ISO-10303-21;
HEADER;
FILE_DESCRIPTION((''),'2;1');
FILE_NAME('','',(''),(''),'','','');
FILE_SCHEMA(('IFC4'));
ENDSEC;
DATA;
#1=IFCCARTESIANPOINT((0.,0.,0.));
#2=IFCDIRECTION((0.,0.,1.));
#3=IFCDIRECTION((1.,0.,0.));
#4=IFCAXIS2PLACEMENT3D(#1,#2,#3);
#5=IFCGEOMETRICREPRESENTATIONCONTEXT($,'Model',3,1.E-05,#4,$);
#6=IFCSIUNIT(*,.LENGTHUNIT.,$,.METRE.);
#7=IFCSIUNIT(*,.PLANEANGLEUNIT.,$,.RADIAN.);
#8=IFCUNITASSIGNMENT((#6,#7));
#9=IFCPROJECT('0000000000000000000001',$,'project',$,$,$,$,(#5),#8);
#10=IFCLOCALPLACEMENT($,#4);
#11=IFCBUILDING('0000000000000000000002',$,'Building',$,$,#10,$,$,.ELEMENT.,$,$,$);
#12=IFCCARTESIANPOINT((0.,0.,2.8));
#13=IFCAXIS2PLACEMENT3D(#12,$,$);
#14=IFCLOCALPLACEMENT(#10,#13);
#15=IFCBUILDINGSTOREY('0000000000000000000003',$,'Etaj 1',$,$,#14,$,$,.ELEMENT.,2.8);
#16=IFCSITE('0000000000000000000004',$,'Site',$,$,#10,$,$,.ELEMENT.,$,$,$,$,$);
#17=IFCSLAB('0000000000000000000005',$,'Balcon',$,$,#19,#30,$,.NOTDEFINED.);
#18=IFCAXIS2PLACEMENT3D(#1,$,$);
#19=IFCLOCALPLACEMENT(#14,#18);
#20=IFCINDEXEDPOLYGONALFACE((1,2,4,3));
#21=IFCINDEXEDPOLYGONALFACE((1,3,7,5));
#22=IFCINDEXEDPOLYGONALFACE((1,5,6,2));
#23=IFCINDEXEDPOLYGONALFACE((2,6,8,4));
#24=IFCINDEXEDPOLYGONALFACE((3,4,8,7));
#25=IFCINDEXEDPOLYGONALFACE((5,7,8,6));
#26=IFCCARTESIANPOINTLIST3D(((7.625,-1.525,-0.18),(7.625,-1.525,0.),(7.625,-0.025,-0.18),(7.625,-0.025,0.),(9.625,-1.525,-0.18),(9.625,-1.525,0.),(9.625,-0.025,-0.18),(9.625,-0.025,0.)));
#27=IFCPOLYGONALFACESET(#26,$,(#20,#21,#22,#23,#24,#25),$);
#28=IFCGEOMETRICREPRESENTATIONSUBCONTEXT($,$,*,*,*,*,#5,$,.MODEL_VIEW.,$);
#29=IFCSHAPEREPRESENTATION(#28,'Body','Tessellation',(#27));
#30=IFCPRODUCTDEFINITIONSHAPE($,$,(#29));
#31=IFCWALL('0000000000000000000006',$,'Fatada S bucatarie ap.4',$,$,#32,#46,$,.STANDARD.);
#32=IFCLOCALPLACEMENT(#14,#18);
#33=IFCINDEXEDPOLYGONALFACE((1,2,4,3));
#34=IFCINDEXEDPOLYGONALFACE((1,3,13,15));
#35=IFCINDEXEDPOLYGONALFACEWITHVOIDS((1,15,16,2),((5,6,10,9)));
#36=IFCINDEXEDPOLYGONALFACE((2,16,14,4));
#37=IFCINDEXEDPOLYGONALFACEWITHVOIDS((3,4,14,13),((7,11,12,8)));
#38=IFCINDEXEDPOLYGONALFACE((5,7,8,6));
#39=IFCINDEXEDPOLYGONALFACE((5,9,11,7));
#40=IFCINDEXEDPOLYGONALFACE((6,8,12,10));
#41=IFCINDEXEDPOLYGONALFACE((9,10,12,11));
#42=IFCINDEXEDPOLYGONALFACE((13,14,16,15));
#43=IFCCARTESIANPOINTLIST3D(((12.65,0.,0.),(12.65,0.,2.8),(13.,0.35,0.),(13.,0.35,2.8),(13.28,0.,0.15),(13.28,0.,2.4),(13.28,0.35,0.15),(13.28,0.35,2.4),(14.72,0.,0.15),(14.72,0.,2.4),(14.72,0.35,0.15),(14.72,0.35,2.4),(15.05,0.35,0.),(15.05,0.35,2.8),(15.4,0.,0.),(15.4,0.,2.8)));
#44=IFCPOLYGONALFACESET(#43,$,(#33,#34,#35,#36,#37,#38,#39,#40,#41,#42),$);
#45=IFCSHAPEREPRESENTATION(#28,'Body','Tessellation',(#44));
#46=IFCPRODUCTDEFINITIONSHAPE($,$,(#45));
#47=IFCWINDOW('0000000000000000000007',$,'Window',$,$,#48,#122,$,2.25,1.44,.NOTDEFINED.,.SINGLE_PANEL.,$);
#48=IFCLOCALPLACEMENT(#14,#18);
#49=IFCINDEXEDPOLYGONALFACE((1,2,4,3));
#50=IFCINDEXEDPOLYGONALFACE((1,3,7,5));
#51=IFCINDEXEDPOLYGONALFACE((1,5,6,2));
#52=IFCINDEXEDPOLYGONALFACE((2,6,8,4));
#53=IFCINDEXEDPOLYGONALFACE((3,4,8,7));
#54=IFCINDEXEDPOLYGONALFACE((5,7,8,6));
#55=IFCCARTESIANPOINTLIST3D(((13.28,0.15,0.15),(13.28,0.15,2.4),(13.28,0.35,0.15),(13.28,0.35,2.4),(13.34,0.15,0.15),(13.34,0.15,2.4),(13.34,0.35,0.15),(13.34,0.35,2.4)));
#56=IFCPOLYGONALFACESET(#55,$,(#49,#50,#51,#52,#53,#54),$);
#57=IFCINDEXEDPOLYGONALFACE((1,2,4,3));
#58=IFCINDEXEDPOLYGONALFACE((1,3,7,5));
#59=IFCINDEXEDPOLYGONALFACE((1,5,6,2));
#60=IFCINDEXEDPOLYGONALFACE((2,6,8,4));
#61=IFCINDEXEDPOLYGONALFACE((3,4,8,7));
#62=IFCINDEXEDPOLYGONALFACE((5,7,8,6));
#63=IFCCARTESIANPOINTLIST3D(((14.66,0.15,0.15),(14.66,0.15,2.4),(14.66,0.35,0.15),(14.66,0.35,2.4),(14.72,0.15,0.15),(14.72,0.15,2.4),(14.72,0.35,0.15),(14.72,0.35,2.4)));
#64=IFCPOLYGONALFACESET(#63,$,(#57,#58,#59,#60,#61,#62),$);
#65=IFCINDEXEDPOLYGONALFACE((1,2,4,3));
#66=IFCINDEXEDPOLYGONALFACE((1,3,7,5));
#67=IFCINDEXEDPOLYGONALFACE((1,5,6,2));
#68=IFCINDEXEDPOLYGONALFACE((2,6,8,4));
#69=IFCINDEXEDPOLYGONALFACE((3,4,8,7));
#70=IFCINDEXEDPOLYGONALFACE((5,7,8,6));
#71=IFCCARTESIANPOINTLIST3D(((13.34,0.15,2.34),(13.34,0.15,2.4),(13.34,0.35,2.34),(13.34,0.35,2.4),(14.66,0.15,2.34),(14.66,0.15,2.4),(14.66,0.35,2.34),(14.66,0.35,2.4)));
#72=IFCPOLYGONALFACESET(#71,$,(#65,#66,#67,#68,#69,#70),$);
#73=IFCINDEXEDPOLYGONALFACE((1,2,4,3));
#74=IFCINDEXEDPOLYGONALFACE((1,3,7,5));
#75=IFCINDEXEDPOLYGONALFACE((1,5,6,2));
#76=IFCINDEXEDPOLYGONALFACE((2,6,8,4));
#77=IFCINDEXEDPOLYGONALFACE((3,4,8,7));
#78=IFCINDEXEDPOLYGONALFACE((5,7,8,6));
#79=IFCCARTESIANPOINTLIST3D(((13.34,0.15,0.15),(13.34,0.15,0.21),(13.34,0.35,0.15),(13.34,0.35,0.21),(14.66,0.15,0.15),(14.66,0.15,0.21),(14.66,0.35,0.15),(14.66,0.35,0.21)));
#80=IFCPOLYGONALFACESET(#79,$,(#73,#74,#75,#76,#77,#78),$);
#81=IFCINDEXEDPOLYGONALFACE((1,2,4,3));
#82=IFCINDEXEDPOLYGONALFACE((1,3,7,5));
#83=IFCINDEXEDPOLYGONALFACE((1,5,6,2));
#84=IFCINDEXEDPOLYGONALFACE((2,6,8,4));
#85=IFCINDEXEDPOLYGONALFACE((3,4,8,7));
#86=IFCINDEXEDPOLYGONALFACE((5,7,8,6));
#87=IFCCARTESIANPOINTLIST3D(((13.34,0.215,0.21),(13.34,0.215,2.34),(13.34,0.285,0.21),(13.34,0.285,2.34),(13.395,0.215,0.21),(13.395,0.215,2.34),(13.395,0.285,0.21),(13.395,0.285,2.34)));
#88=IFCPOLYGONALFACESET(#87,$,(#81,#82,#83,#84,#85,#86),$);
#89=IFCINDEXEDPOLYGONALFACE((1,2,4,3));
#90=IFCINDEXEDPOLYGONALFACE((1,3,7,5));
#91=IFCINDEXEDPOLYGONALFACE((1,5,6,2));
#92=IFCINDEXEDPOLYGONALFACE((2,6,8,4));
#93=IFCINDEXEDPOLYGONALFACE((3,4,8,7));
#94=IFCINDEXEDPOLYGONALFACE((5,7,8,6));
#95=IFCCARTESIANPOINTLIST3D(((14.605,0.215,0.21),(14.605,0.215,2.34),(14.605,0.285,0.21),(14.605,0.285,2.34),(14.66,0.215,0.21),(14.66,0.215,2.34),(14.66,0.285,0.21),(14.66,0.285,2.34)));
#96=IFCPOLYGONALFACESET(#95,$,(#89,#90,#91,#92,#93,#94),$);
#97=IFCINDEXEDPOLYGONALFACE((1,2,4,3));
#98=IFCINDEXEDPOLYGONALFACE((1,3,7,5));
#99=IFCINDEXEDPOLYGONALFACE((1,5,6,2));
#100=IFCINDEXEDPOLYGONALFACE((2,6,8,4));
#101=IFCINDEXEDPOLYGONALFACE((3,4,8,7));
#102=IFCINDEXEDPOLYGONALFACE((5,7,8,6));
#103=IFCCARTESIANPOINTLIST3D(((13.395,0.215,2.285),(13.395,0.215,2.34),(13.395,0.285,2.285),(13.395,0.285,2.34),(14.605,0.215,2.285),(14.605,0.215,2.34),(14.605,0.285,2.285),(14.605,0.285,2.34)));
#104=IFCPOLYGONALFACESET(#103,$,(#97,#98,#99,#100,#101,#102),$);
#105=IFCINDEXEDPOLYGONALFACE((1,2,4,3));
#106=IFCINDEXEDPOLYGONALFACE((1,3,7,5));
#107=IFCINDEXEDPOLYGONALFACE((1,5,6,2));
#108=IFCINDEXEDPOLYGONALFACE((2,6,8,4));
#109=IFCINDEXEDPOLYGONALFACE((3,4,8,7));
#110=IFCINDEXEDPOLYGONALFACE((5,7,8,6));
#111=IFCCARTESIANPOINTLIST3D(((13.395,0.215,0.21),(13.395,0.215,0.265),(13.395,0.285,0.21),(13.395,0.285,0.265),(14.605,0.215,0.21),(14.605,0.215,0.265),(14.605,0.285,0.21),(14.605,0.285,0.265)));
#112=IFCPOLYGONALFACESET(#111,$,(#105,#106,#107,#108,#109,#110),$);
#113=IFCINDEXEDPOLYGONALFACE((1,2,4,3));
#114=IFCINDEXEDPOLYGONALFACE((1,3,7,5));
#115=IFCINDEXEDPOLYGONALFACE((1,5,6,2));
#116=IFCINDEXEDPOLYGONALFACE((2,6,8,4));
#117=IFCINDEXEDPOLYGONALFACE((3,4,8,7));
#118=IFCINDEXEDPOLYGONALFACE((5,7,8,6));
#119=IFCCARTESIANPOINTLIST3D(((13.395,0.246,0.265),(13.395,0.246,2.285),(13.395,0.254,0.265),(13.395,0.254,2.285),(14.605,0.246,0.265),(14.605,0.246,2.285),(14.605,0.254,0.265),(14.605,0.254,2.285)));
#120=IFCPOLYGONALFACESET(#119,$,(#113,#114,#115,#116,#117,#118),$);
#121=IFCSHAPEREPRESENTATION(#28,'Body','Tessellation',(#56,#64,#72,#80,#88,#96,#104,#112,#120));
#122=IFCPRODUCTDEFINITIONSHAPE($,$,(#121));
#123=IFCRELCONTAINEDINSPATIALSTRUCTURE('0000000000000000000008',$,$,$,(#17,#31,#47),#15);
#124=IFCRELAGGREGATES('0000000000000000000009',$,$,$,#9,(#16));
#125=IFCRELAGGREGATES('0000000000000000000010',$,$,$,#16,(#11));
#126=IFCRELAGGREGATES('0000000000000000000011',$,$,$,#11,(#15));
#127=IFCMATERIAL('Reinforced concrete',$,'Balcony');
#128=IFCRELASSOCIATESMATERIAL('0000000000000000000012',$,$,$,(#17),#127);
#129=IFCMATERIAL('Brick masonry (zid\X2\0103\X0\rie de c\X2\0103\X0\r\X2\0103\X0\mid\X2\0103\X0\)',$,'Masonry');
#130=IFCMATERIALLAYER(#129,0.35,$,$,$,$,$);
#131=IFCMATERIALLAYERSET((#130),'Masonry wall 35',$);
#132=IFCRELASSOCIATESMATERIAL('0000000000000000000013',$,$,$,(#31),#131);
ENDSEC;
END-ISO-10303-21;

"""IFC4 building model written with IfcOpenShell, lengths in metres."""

from ifc_helpers import new_model, si_unit, frame, frame_2d, origin, origin_with_axes, origin_2d, place, context, subcontext, project, spatial, polyline, rectangle, outline, extrude, clip, halfspace, material, layer, layer_set, layer_usage, element, fill, save


model = new_model("IFC4")

# Units and contexts
model_context = context("Model", 3, precision=1e-05, world=origin_with_axes())
sub_context = subcontext(model_context, None, None, "MODEL_VIEW")
ifc_project = project(units=[si_unit("LENGTHUNIT", "METRE"), si_unit("PLANEANGLEUNIT", "RADIAN")], contexts=[model_context])

# Site, building, storey
placement = place(None, origin_with_axes())
site = spatial("IfcSite", under=ifc_project, at=placement, Name="Site", CompositionType="ELEMENT")
building = spatial("IfcBuilding", under=site, at=placement, Name="Building", CompositionType="ELEMENT")
storey_placement = place(placement, frame((0.0, 0.0, 2.8)))
storey = spatial("IfcBuildingStorey", under=building, at=storey_placement, Name="Etaj 1", CompositionType="ELEMENT", Elevation=2.8)

# Slab
ifc_material_1 = material(Name="Reinforced concrete", Category="Balcony")
slab_placement = place(storey_placement, frame((7.625, -1.525, -0.18), z_axis=(0.0, 0.0, 1.0), x_axis=(1.0, 0.0, 0.0)))
element("IfcSlab", 1, at=slab_placement, inside=storey, material=ifc_material_1, Name="Balcon", PredefinedType="NOTDEFINED", context=sub_context, shape_type="SweptSolid", body=[
    extrude(outline(polyline([(0.0, 0.0), (2.0, 0.0), (2.0, 1.5), (0.0, 1.5), (0.0, 0.0)])), origin(), (0.0, 0.0, 1.0), 0.18),
])

# Wall, opening, window
ifc_material_2 = material(Name="Brick masonry (zidărie de cărămidă)", Category="Masonry")
ifc_layer_1 = layer(ifc_material_2, 0.35)
ifc_layer_set_1 = layer_set([ifc_layer_1], Name="Masonry wall 35")
ifc_layer_usage_1 = layer_usage(ifc_layer_set_1, "AXIS2", "POSITIVE", -0.175)
wall_1_placement = place(storey_placement, frame((12.65, 0.175, 0.0), x_axis=(1.0, 0.0, 0.0)))
wall_1 = element("IfcWall", 2, at=wall_1_placement, inside=storey, material=ifc_layer_usage_1, Name="Fatada S bucatarie ap.4", PredefinedType="STANDARD", context=sub_context, shape_type="CSG", body=[
    clip(clip(extrude(rectangle(XDim=2.75, YDim=0.35, at=frame_2d((1.375, 0.0))), origin(), (0.0, 0.0, 1.0), 2.8), halfspace(frame((0.175, 0.0, 0.0), z_axis=(-0.707107, 0.707107, 0.0)), False)), halfspace(frame((2.575, 0.0, 0.0), z_axis=(0.707107, 0.707107, 0.0)), False)),
])
opening_1_placement = place(wall_1_placement, frame((1.35, 0.225, 0.15), z_axis=(0.0, -1.0, 0.0), x_axis=(1.0, 0.0, 0.0)))
opening_1 = element("IfcOpeningElement", 3, at=opening_1_placement, cuts=wall_1, PredefinedType="OPENING", context=sub_context, shape_type="SweptSolid", body=[
    extrude(rectangle(XDim=1.44, YDim=2.25, at=frame_2d((0.0, 1.125))), origin(), (0.0, 0.0, 1.0), 0.45),
])
window_1_placement = place(wall_1_placement, frame((1.35, 0.175, 0.15), z_axis=(0.0, -1.0, 0.0), x_axis=(1.0, 0.0, 0.0)))
window_1 = element("IfcWindow", 4, at=window_1_placement, inside=storey, Name="Window", OverallHeight=2.25, OverallWidth=1.44, PartitioningType="SINGLE_PANEL", PredefinedType="NOTDEFINED", context=sub_context, shape_type="SweptSolid", body=[
    extrude(rectangle(XDim=0.06, YDim=2.25, at=origin_2d()), frame((-0.69, 1.125, 0.0)), (0.0, 0.0, 1.0), 0.2),
    extrude(rectangle(XDim=0.06, YDim=2.25, at=origin_2d()), frame((0.69, 1.125, 0.0)), (0.0, 0.0, 1.0), 0.2),
    extrude(rectangle(XDim=1.32, YDim=0.06, at=origin_2d()), frame((0.0, 2.22, 0.0)), (0.0, 0.0, 1.0), 0.2),
    extrude(rectangle(XDim=1.32, YDim=0.06, at=origin_2d()), frame((0.0, 0.03, 0.0)), (0.0, 0.0, 1.0), 0.2),
    extrude(rectangle(XDim=0.055, YDim=2.13, at=origin_2d()), frame((-0.6325, 1.125, 0.065)), (0.0, 0.0, 1.0), 0.07),
    extrude(rectangle(XDim=0.055, YDim=2.13, at=origin_2d()), frame((0.6325, 1.125, 0.065)), (0.0, 0.0, 1.0), 0.07),
    extrude(rectangle(XDim=1.21, YDim=0.055, at=origin_2d()), frame((0.0, 2.1625, 0.065)), (0.0, 0.0, 1.0), 0.07),
    extrude(rectangle(XDim=1.21, YDim=0.055, at=origin_2d()), frame((0.0, 0.0875, 0.065)), (0.0, 0.0, 1.0), 0.07),
    extrude(rectangle(XDim=1.21, YDim=2.02, at=origin_2d()), frame((0.0, 1.125, 0.096)), (0.0, 0.0, 1.0), 0.008),
])
fill(opening_1, window_1)

save(model, "model.ifc")
